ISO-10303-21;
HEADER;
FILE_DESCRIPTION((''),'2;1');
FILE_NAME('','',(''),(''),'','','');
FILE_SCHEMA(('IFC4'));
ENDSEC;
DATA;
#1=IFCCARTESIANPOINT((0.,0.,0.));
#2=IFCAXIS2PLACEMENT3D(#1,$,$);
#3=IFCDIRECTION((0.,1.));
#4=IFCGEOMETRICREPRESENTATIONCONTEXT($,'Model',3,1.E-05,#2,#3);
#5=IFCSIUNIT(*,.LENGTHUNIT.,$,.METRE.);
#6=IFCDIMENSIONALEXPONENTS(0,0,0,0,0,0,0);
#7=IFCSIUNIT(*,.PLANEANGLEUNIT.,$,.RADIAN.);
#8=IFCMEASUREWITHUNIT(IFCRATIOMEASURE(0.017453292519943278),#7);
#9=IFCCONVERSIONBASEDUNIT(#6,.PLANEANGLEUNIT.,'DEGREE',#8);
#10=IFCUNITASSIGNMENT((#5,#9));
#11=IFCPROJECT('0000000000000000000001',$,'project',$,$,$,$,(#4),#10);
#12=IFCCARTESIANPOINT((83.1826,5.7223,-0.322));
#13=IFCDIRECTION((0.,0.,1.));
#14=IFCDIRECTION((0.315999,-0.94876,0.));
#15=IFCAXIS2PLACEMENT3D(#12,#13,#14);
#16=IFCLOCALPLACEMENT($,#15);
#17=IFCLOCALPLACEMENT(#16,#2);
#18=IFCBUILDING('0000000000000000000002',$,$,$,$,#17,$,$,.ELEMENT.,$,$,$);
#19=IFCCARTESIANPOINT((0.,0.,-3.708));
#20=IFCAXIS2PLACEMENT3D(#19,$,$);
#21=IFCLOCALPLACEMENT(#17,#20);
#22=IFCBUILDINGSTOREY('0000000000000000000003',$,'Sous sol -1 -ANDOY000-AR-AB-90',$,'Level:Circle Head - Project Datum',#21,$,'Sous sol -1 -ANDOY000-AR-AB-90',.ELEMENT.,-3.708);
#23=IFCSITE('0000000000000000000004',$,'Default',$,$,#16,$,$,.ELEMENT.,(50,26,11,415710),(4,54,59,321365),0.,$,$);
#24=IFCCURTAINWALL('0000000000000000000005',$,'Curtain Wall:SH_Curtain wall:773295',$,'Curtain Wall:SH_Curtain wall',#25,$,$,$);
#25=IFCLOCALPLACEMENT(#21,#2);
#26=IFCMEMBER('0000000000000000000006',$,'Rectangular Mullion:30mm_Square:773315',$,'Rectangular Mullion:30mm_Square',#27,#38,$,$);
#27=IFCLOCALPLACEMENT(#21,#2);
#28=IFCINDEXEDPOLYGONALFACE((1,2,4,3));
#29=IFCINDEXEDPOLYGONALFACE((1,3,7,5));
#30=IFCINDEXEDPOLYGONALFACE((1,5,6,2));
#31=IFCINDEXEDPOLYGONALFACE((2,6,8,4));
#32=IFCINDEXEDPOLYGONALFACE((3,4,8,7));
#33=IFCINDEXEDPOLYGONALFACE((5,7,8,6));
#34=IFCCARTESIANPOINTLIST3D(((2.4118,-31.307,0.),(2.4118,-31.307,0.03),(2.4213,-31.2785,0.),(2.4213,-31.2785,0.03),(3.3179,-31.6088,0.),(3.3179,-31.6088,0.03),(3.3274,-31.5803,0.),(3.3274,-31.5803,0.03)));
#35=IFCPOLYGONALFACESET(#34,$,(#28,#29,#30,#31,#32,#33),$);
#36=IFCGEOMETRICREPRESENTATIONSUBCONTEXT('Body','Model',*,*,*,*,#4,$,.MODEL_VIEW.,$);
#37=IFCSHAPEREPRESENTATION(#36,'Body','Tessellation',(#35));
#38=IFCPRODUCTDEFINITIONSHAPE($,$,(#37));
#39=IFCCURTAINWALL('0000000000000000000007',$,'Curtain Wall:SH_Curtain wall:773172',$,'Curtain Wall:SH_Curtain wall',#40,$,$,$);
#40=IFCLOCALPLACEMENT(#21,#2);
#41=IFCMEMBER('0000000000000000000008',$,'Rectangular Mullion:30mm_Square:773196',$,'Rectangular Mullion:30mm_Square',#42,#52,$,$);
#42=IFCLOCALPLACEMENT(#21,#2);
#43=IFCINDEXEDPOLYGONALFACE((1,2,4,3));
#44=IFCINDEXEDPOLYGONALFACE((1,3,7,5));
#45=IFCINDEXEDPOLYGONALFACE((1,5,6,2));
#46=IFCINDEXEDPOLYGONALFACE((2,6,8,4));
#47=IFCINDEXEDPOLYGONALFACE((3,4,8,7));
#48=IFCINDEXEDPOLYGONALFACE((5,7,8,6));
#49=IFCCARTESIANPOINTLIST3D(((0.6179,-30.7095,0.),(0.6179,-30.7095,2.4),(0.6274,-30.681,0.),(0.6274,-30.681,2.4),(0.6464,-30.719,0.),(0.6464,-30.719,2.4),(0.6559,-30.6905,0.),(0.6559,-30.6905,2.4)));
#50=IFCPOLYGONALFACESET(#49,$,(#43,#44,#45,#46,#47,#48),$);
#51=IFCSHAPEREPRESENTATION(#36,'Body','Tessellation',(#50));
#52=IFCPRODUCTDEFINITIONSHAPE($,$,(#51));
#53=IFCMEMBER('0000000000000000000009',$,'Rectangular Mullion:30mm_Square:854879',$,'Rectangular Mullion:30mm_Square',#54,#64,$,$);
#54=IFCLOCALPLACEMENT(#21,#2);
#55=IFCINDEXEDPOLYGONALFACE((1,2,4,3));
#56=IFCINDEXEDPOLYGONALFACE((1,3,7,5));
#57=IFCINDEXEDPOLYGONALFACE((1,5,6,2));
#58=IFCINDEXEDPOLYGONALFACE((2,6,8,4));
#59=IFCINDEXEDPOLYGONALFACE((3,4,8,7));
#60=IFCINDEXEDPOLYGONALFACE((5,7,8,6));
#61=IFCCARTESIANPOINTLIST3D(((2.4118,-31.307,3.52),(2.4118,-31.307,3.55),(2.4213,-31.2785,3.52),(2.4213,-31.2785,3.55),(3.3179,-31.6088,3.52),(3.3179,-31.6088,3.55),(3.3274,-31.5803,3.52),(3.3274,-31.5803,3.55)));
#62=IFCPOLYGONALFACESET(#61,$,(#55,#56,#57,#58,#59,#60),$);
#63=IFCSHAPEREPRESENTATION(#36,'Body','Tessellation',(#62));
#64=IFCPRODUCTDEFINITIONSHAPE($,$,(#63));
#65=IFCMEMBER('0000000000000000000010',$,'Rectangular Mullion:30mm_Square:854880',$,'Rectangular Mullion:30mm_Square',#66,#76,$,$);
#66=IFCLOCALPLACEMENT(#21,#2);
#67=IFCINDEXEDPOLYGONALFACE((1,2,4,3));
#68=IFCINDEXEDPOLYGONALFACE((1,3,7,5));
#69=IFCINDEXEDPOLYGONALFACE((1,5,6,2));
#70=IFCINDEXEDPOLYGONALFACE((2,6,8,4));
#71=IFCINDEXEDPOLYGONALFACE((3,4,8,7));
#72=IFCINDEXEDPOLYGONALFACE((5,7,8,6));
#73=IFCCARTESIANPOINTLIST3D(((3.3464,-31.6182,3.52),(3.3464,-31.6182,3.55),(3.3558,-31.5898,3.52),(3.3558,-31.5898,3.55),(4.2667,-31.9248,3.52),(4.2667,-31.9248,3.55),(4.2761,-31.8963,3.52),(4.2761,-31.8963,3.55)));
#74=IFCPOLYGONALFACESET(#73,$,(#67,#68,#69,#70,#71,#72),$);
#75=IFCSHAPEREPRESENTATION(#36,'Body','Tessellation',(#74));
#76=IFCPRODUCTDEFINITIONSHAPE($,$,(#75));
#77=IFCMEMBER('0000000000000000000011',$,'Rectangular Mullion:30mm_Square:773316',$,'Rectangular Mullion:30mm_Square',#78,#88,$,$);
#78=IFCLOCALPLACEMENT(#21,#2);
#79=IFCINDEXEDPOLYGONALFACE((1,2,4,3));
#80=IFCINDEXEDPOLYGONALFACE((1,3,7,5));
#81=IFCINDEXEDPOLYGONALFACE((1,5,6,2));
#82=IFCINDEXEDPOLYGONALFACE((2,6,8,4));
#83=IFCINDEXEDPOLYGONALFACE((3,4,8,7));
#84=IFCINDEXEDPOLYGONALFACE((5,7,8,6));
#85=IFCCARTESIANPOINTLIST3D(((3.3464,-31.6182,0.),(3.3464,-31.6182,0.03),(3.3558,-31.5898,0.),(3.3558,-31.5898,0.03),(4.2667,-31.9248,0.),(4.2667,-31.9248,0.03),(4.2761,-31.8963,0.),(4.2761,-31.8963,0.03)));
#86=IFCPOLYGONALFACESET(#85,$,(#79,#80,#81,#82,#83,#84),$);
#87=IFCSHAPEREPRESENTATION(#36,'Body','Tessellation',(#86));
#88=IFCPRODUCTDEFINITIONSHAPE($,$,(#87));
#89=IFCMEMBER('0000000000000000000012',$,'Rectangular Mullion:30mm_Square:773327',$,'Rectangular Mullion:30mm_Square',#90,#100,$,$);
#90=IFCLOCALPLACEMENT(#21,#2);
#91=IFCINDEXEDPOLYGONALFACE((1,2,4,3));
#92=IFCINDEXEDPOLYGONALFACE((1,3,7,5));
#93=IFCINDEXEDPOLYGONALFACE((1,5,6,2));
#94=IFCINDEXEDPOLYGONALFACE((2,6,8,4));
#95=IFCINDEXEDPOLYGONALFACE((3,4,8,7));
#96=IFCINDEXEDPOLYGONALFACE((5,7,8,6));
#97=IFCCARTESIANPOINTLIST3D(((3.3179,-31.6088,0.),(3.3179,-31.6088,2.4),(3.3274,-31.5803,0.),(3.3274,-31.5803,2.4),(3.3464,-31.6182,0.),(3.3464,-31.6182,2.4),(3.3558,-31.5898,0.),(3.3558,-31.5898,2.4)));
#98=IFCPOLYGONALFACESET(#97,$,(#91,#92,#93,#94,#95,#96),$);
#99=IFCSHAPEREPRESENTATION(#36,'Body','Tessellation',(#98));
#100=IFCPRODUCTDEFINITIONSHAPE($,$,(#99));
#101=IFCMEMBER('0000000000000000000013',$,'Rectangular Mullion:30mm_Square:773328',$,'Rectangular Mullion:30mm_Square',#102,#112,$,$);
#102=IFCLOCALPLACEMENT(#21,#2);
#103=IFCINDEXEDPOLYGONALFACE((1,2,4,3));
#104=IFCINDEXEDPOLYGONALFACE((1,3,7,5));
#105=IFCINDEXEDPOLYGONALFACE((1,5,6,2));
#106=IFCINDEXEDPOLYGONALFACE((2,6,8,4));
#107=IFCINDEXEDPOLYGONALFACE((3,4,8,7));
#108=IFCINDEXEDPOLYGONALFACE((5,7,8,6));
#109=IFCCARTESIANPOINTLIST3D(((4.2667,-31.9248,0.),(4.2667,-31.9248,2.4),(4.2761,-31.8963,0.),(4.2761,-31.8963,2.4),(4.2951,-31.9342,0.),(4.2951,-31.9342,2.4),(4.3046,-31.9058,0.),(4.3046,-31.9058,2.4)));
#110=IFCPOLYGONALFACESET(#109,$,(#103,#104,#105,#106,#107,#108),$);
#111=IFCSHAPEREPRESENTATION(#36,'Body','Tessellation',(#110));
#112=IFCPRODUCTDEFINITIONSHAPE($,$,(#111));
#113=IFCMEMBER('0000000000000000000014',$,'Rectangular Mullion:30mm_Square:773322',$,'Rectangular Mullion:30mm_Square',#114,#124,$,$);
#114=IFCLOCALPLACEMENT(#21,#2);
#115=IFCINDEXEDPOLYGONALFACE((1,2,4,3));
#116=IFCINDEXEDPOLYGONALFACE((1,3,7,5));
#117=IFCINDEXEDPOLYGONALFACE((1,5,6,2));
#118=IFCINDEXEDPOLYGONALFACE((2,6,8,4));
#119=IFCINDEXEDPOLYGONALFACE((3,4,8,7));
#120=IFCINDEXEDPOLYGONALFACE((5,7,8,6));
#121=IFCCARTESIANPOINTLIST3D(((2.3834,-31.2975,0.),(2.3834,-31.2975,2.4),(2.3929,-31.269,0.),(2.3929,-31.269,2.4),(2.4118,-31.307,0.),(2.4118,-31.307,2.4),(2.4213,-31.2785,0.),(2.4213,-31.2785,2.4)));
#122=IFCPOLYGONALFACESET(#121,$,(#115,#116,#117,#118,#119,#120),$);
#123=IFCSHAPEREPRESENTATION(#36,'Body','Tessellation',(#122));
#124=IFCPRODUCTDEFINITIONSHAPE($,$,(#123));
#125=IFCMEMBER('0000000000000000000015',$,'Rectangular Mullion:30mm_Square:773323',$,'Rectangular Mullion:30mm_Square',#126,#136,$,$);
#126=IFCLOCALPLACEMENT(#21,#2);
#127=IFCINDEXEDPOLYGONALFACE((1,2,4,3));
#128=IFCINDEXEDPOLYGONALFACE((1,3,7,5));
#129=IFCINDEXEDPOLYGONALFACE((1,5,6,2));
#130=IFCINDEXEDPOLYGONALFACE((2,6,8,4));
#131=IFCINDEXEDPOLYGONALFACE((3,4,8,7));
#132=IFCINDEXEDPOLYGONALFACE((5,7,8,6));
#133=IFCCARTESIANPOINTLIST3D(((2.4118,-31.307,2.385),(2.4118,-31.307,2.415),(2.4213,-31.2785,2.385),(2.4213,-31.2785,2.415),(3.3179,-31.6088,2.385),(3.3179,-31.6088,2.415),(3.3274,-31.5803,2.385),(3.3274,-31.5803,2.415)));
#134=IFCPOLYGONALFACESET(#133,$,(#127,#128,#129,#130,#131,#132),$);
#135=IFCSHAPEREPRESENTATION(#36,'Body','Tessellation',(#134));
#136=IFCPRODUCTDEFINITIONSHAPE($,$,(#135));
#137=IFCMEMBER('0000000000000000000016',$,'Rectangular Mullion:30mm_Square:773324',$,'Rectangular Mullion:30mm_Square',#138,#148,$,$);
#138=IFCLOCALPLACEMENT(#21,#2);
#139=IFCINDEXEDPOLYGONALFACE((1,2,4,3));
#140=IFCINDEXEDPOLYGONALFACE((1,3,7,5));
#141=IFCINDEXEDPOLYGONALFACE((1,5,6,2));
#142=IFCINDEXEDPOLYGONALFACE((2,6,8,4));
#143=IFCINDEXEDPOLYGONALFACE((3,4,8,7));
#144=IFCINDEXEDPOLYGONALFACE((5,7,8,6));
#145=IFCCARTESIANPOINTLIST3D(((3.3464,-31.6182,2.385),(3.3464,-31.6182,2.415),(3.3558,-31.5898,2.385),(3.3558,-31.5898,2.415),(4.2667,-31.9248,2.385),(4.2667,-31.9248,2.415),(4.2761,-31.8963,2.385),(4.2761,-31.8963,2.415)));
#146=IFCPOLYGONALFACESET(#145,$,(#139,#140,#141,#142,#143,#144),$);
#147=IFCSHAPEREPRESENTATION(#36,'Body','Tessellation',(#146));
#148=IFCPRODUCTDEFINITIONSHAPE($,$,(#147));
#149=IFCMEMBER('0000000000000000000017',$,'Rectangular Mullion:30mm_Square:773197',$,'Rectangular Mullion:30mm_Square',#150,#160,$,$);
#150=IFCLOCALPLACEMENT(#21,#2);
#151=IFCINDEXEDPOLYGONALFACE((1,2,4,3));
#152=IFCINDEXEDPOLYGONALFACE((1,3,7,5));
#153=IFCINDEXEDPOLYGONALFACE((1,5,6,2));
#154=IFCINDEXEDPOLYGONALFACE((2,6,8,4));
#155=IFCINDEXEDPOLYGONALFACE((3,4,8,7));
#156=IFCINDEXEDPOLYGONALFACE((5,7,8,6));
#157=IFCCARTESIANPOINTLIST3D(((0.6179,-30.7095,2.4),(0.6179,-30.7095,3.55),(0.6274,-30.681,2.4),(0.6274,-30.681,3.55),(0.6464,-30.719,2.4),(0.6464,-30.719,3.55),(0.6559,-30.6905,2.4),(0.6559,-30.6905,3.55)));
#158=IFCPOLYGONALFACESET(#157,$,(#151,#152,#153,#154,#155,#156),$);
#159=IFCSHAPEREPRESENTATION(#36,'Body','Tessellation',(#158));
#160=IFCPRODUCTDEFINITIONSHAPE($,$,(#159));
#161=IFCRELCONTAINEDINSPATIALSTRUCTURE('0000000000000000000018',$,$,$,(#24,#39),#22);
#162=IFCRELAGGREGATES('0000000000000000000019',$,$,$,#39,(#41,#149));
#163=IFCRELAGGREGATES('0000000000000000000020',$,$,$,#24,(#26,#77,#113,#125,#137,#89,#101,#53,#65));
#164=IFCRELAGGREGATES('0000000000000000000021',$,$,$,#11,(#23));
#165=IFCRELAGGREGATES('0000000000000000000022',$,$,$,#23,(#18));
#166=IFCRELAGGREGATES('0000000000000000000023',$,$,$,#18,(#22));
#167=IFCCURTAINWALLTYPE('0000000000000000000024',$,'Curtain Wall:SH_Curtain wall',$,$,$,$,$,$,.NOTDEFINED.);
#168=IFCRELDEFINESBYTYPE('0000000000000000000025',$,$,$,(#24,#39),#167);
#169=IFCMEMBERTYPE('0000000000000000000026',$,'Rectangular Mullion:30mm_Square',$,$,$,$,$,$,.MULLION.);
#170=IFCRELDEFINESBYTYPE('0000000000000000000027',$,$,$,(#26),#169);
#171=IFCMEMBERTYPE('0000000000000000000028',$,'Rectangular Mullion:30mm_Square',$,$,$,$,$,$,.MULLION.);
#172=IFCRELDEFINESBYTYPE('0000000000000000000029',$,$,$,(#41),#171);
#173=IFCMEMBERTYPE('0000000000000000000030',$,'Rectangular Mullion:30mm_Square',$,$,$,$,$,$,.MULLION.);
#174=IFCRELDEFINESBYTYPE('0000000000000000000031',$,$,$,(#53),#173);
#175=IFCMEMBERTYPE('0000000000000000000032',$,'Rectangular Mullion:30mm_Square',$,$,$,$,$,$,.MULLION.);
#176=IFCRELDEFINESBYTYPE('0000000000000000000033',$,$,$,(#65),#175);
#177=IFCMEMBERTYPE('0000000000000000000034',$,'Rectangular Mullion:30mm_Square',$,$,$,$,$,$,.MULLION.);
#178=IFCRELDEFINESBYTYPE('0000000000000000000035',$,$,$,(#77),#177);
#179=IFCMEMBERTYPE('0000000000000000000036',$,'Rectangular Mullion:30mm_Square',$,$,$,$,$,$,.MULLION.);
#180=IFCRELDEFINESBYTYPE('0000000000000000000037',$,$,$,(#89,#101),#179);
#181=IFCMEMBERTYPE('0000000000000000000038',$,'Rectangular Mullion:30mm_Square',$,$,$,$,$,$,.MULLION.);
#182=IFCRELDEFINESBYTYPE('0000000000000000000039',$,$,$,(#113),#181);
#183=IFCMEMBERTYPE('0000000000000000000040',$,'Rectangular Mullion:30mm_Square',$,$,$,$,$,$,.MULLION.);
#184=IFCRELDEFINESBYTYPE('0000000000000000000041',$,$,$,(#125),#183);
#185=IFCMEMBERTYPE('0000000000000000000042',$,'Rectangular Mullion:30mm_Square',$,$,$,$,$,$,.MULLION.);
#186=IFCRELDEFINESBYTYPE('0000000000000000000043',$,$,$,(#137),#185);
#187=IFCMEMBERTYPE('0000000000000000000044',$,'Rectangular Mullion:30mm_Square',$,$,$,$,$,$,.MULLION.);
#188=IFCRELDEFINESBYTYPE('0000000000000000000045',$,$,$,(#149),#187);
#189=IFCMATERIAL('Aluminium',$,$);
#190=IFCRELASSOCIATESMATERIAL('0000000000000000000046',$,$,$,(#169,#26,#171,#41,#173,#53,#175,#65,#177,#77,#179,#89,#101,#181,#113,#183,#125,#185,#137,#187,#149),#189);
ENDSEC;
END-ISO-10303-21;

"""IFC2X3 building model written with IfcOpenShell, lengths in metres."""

from ifc_helpers import new_model, entity, si_unit, converted_unit, direction, frame, origin, origin_2d_with_axis, place, context, subcontext, project, spatial, rectangle, extrude, source, transform, mapped, material, type_object, type_shapes, element, aggregate, save


model = new_model("IFC2X3")

# Units and contexts
model_context = context("Model", 3, precision=1e-05, world=origin(), true_north=direction((0.0, 1.0)))
body_context = subcontext(model_context, "Body", "Model", "MODEL_VIEW")
ifc_project = project(units=[si_unit("LENGTHUNIT", "METRE"), converted_unit("PLANEANGLEUNIT", "DEGREE", entity("IfcRatioMeasure", 0.017453292519943278), si_unit("PLANEANGLEUNIT", "RADIAN"), dimensions=[0, 0, 0, 0, 0, 0, 0])], contexts=[model_context])

# Site, building, storey
site_placement = place(None, frame((83.1826, 5.7223, -0.322), z_axis=(0.0, 0.0, 1.0), x_axis=(0.315999, -0.94876, 0.0)))
site = spatial("IfcSite", under=ifc_project, at=site_placement, Name="Default", CompositionType="ELEMENT", RefLatitude=(50, 26, 11, 415710), RefLongitude=(4, 54, 59, 321365), RefElevation=0.0)
building_placement = place(site_placement, origin())
building = spatial("IfcBuilding", under=site, at=building_placement, CompositionType="ELEMENT")
storey_placement = place(building_placement, frame((0.0, 0.0, -3.708)))
storey = spatial("IfcBuildingStorey", under=building, at=storey_placement, Name="Sous sol -1 -ANDOY000-AR-AB-90", ObjectType="Level:Circle Head - Project Datum", LongName="Sous sol -1 -ANDOY000-AR-AB-90", CompositionType="ELEMENT", Elevation=-3.708)

# Curtain walls, members
curtain_wall_type = type_object("IfcCurtainWallType", Name="Curtain Wall:SH_Curtain wall", PredefinedType="NOTDEFINED")
curtain_wall_1_placement = place(storey_placement, frame((0.0, 0.0, 3.708)))
curtain_wall_1 = element("IfcCurtainWall", 1, at=curtain_wall_1_placement, inside=storey, type_object=curtain_wall_type, Name="Curtain Wall:SH_Curtain wall:773295", ObjectType="Curtain Wall:SH_Curtain wall")
ifc_material_1 = material(Name="Aluminium")
member_type_1 = type_object("IfcMemberType", Name="Rectangular Mullion:30mm_Square", PredefinedType="MULLION", material=ifc_material_1)
shared_shape_1 = source(origin(), body_context, "Body", "SweptSolid", [
    extrude(rectangle(XDim=0.03, YDim=0.03, at=origin_2d_with_axis()), frame((-0.015, 0.0, -0.955), z_axis=(0.0, 0.0, 1.0), x_axis=(0.0, -1.0, 0.0)), (0.0, 0.0, 1.0), 0.955),
])
type_shapes(member_type_1, [shared_shape_1])
member_1_placement = place(curtain_wall_1_placement, frame((2.4166, -31.2928, -3.708), z_axis=(-0.948759, 0.316, 0.0), x_axis=(0.0, 0.0, -1.0)))
member_1 = element("IfcMember", 2, at=member_1_placement, type_object=member_type_1, material=ifc_material_1, Name="Rectangular Mullion:30mm_Square:773315", ObjectType="Rectangular Mullion:30mm_Square", context=body_context, shape_type="MappedRepresentation", body=[
    mapped(shared_shape_1, transform((0.0, 0.0, 0.0), scale=1.0)),
])
curtain_wall_2_placement = place(storey_placement, frame((0.0, 0.0, 3.708)))
curtain_wall_2 = element("IfcCurtainWall", 3, at=curtain_wall_2_placement, inside=storey, type_object=curtain_wall_type, Name="Curtain Wall:SH_Curtain wall:773172", ObjectType="Curtain Wall:SH_Curtain wall")
member_type_2 = type_object("IfcMemberType", Name="Rectangular Mullion:30mm_Square", PredefinedType="MULLION", material=ifc_material_1)
shared_shape_2 = source(origin(), body_context, "Body", "SweptSolid", [
    extrude(rectangle(XDim=0.03, YDim=0.03, at=origin_2d_with_axis()), frame((-0.015, 0.0, -2.4), z_axis=(0.0, 0.0, 1.0), x_axis=(0.0, -1.0, 0.0)), (0.0, 0.0, 1.0), 2.4),
])
type_shapes(member_type_2, [shared_shape_2])
member_2_placement = place(curtain_wall_2_placement, frame((0.6511, -30.7047, -3.708), z_axis=(0.0, 0.0, -1.0), x_axis=(0.948759, -0.316, 0.0)))
member_2 = element("IfcMember", 4, at=member_2_placement, type_object=member_type_2, material=ifc_material_1, Name="Rectangular Mullion:30mm_Square:773196", ObjectType="Rectangular Mullion:30mm_Square", context=body_context, shape_type="MappedRepresentation", body=[
    mapped(shared_shape_2, transform((0.0, 0.0, 0.0), scale=1.0)),
])

# Members
member_type_3 = type_object("IfcMemberType", Name="Rectangular Mullion:30mm_Square", PredefinedType="MULLION", material=ifc_material_1)
shared_shape_3 = source(origin(), body_context, "Body", "SweptSolid", [
    extrude(rectangle(XDim=0.03, YDim=0.03, at=origin_2d_with_axis()), frame((-0.015, 0.0, -0.955), z_axis=(0.0, 0.0, 1.0), x_axis=(0.0, -1.0, 0.0)), (0.0, 0.0, 1.0), 0.955),
])
type_shapes(member_type_3, [shared_shape_3])
member_3_placement = place(curtain_wall_1_placement, frame((3.3226, -31.5945, -0.158), z_axis=(0.948759, -0.316, 0.0), x_axis=(0.0, 0.0, 1.0)))
member_3 = element("IfcMember", 5, at=member_3_placement, type_object=member_type_3, material=ifc_material_1, Name="Rectangular Mullion:30mm_Square:854879", ObjectType="Rectangular Mullion:30mm_Square", context=body_context, shape_type="MappedRepresentation", body=[
    mapped(shared_shape_3, transform((0.0, 0.0, 0.0), scale=1.0)),
])
member_type_4 = type_object("IfcMemberType", Name="Rectangular Mullion:30mm_Square", PredefinedType="MULLION", material=ifc_material_1)
shared_shape_4 = source(origin(), body_context, "Body", "SweptSolid", [
    extrude(rectangle(XDim=0.03, YDim=0.03, at=origin_2d_with_axis()), frame((-0.015, 0.0, -0.97), z_axis=(0.0, 0.0, 1.0), x_axis=(0.0, -1.0, 0.0)), (0.0, 0.0, 1.0), 0.97),
])
type_shapes(member_type_4, [shared_shape_4])
member_4_placement = place(curtain_wall_1_placement, frame((4.2714, -31.9105, -0.158), z_axis=(0.948759, -0.316, 0.0), x_axis=(0.0, 0.0, 1.0)))
member_4 = element("IfcMember", 6, at=member_4_placement, type_object=member_type_4, material=ifc_material_1, Name="Rectangular Mullion:30mm_Square:854880", ObjectType="Rectangular Mullion:30mm_Square", context=body_context, shape_type="MappedRepresentation", body=[
    mapped(shared_shape_4, transform((0.0, 0.0, 0.0), scale=1.0)),
])
member_type_5 = type_object("IfcMemberType", Name="Rectangular Mullion:30mm_Square", PredefinedType="MULLION", material=ifc_material_1)
shared_shape_5 = source(origin(), body_context, "Body", "SweptSolid", [
    extrude(rectangle(XDim=0.03, YDim=0.03, at=origin_2d_with_axis()), frame((-0.015, 0.0, -0.97), z_axis=(0.0, 0.0, 1.0), x_axis=(0.0, -1.0, 0.0)), (0.0, 0.0, 1.0), 0.97),
])
type_shapes(member_type_5, [shared_shape_5])
member_5_placement = place(curtain_wall_1_placement, frame((3.3511, -31.604, -3.708), z_axis=(-0.948759, 0.316, 0.0), x_axis=(0.0, 0.0, -1.0)))
member_5 = element("IfcMember", 7, at=member_5_placement, type_object=member_type_5, material=ifc_material_1, Name="Rectangular Mullion:30mm_Square:773316", ObjectType="Rectangular Mullion:30mm_Square", context=body_context, shape_type="MappedRepresentation", body=[
    mapped(shared_shape_5, transform((0.0, 0.0, 0.0), scale=1.0)),
])
member_type_6 = type_object("IfcMemberType", Name="Rectangular Mullion:30mm_Square", PredefinedType="MULLION", material=ifc_material_1)
shared_shape_6 = source(origin(), body_context, "Body", "SweptSolid", [
    extrude(rectangle(XDim=0.03, YDim=0.03, at=origin_2d_with_axis()), frame((0.0, 0.0, -2.4), z_axis=(0.0, 0.0, 1.0), x_axis=(0.0, -1.0, 0.0)), (0.0, 0.0, 1.0), 2.4),
])
type_shapes(member_type_6, [shared_shape_6])
member_6_placement = place(curtain_wall_1_placement, frame((3.3369, -31.5993, -3.708), z_axis=(0.0, 0.0, -1.0), x_axis=(0.948759, -0.316, 0.0)))
member_6 = element("IfcMember", 8, at=member_6_placement, type_object=member_type_6, material=ifc_material_1, Name="Rectangular Mullion:30mm_Square:773327", ObjectType="Rectangular Mullion:30mm_Square", context=body_context, shape_type="MappedRepresentation", body=[
    mapped(shared_shape_6, transform((0.0, 0.0, 0.0), scale=1.0)),
])
member_7_placement = place(curtain_wall_1_placement, frame((4.2856, -31.9153, -3.708), z_axis=(0.0, 0.0, -1.0), x_axis=(0.948759, -0.316, 0.0)))
member_7 = element("IfcMember", 9, at=member_7_placement, type_object=member_type_6, material=ifc_material_1, Name="Rectangular Mullion:30mm_Square:773328", ObjectType="Rectangular Mullion:30mm_Square", context=body_context, shape_type="MappedRepresentation", body=[
    mapped(shared_shape_6, transform((0.0, 0.0, 0.0), scale=1.0)),
])
member_type_7 = type_object("IfcMemberType", Name="Rectangular Mullion:30mm_Square", PredefinedType="MULLION", material=ifc_material_1)
shared_shape_7 = source(origin(), body_context, "Body", "SweptSolid", [
    extrude(rectangle(XDim=0.03, YDim=0.03, at=origin_2d_with_axis()), frame((-0.015, 0.0, -2.4), z_axis=(0.0, 0.0, 1.0), x_axis=(0.0, -1.0, 0.0)), (0.0, 0.0, 1.0), 2.4),
])
type_shapes(member_type_7, [shared_shape_7])
member_8_placement = place(curtain_wall_1_placement, frame((2.3881, -31.2833, -1.308), z_axis=(0.0, 0.0, 1.0), x_axis=(-0.948759, 0.316, 0.0)))
member_8 = element("IfcMember", 10, at=member_8_placement, type_object=member_type_7, material=ifc_material_1, Name="Rectangular Mullion:30mm_Square:773322", ObjectType="Rectangular Mullion:30mm_Square", context=body_context, shape_type="MappedRepresentation", body=[
    mapped(shared_shape_7, transform((0.0, 0.0, 0.0), scale=1.0)),
])
member_type_8 = type_object("IfcMemberType", Name="Rectangular Mullion:30mm_Square", PredefinedType="MULLION", material=ifc_material_1)
shared_shape_8 = source(origin(), body_context, "Body", "SweptSolid", [
    extrude(rectangle(XDim=0.03, YDim=0.03, at=origin_2d_with_axis()), frame((0.0, 0.0, -0.955), z_axis=(0.0, 0.0, 1.0), x_axis=(0.0, -1.0, 0.0)), (0.0, 0.0, 1.0), 0.955),
])
type_shapes(member_type_8, [shared_shape_8])
member_9_placement = place(curtain_wall_1_placement, frame((3.3226, -31.5945, -1.308), z_axis=(0.948759, -0.316, 0.0), x_axis=(0.0, 0.0, 1.0)))
member_9 = element("IfcMember", 11, at=member_9_placement, type_object=member_type_8, material=ifc_material_1, Name="Rectangular Mullion:30mm_Square:773323", ObjectType="Rectangular Mullion:30mm_Square", context=body_context, shape_type="MappedRepresentation", body=[
    mapped(shared_shape_8, transform((0.0, 0.0, 0.0), scale=1.0)),
])
member_type_9 = type_object("IfcMemberType", Name="Rectangular Mullion:30mm_Square", PredefinedType="MULLION", material=ifc_material_1)
shared_shape_9 = source(origin(), body_context, "Body", "SweptSolid", [
    extrude(rectangle(XDim=0.03, YDim=0.03, at=origin_2d_with_axis()), frame((0.0, 0.0, -0.97), z_axis=(0.0, 0.0, 1.0), x_axis=(0.0, -1.0, 0.0)), (0.0, 0.0, 1.0), 0.97),
])
type_shapes(member_type_9, [shared_shape_9])
member_10_placement = place(curtain_wall_1_placement, frame((4.2714, -31.9105, -1.308), z_axis=(0.948759, -0.316, 0.0), x_axis=(0.0, 0.0, 1.0)))
member_10 = element("IfcMember", 12, at=member_10_placement, type_object=member_type_9, material=ifc_material_1, Name="Rectangular Mullion:30mm_Square:773324", ObjectType="Rectangular Mullion:30mm_Square", context=body_context, shape_type="MappedRepresentation", body=[
    mapped(shared_shape_9, transform((0.0, 0.0, 0.0), scale=1.0)),
])
member_type_10 = type_object("IfcMemberType", Name="Rectangular Mullion:30mm_Square", PredefinedType="MULLION", material=ifc_material_1)
shared_shape_10 = source(origin(), body_context, "Body", "SweptSolid", [
    extrude(rectangle(XDim=0.03, YDim=0.03, at=origin_2d_with_axis()), frame((-0.015, 0.0, -1.15), z_axis=(0.0, 0.0, 1.0), x_axis=(0.0, -1.0, 0.0)), (0.0, 0.0, 1.0), 1.15),
])
type_shapes(member_type_10, [shared_shape_10])
member_11_placement = place(curtain_wall_2_placement, frame((0.6511, -30.7047, -1.308), z_axis=(0.0, 0.0, -1.0), x_axis=(0.948759, -0.316, 0.0)))
member_11 = element("IfcMember", 13, at=member_11_placement, type_object=member_type_10, material=ifc_material_1, Name="Rectangular Mullion:30mm_Square:773197", ObjectType="Rectangular Mullion:30mm_Square", context=body_context, shape_type="MappedRepresentation", body=[
    mapped(shared_shape_10, transform((0.0, 0.0, 0.0), scale=1.0)),
])
aggregate(curtain_wall_2, [member_2, member_11])

aggregate(curtain_wall_1, [member_1, member_5, member_8, member_9, member_10, member_6, member_7, member_3, member_4])

save(model, "model.ifc")
